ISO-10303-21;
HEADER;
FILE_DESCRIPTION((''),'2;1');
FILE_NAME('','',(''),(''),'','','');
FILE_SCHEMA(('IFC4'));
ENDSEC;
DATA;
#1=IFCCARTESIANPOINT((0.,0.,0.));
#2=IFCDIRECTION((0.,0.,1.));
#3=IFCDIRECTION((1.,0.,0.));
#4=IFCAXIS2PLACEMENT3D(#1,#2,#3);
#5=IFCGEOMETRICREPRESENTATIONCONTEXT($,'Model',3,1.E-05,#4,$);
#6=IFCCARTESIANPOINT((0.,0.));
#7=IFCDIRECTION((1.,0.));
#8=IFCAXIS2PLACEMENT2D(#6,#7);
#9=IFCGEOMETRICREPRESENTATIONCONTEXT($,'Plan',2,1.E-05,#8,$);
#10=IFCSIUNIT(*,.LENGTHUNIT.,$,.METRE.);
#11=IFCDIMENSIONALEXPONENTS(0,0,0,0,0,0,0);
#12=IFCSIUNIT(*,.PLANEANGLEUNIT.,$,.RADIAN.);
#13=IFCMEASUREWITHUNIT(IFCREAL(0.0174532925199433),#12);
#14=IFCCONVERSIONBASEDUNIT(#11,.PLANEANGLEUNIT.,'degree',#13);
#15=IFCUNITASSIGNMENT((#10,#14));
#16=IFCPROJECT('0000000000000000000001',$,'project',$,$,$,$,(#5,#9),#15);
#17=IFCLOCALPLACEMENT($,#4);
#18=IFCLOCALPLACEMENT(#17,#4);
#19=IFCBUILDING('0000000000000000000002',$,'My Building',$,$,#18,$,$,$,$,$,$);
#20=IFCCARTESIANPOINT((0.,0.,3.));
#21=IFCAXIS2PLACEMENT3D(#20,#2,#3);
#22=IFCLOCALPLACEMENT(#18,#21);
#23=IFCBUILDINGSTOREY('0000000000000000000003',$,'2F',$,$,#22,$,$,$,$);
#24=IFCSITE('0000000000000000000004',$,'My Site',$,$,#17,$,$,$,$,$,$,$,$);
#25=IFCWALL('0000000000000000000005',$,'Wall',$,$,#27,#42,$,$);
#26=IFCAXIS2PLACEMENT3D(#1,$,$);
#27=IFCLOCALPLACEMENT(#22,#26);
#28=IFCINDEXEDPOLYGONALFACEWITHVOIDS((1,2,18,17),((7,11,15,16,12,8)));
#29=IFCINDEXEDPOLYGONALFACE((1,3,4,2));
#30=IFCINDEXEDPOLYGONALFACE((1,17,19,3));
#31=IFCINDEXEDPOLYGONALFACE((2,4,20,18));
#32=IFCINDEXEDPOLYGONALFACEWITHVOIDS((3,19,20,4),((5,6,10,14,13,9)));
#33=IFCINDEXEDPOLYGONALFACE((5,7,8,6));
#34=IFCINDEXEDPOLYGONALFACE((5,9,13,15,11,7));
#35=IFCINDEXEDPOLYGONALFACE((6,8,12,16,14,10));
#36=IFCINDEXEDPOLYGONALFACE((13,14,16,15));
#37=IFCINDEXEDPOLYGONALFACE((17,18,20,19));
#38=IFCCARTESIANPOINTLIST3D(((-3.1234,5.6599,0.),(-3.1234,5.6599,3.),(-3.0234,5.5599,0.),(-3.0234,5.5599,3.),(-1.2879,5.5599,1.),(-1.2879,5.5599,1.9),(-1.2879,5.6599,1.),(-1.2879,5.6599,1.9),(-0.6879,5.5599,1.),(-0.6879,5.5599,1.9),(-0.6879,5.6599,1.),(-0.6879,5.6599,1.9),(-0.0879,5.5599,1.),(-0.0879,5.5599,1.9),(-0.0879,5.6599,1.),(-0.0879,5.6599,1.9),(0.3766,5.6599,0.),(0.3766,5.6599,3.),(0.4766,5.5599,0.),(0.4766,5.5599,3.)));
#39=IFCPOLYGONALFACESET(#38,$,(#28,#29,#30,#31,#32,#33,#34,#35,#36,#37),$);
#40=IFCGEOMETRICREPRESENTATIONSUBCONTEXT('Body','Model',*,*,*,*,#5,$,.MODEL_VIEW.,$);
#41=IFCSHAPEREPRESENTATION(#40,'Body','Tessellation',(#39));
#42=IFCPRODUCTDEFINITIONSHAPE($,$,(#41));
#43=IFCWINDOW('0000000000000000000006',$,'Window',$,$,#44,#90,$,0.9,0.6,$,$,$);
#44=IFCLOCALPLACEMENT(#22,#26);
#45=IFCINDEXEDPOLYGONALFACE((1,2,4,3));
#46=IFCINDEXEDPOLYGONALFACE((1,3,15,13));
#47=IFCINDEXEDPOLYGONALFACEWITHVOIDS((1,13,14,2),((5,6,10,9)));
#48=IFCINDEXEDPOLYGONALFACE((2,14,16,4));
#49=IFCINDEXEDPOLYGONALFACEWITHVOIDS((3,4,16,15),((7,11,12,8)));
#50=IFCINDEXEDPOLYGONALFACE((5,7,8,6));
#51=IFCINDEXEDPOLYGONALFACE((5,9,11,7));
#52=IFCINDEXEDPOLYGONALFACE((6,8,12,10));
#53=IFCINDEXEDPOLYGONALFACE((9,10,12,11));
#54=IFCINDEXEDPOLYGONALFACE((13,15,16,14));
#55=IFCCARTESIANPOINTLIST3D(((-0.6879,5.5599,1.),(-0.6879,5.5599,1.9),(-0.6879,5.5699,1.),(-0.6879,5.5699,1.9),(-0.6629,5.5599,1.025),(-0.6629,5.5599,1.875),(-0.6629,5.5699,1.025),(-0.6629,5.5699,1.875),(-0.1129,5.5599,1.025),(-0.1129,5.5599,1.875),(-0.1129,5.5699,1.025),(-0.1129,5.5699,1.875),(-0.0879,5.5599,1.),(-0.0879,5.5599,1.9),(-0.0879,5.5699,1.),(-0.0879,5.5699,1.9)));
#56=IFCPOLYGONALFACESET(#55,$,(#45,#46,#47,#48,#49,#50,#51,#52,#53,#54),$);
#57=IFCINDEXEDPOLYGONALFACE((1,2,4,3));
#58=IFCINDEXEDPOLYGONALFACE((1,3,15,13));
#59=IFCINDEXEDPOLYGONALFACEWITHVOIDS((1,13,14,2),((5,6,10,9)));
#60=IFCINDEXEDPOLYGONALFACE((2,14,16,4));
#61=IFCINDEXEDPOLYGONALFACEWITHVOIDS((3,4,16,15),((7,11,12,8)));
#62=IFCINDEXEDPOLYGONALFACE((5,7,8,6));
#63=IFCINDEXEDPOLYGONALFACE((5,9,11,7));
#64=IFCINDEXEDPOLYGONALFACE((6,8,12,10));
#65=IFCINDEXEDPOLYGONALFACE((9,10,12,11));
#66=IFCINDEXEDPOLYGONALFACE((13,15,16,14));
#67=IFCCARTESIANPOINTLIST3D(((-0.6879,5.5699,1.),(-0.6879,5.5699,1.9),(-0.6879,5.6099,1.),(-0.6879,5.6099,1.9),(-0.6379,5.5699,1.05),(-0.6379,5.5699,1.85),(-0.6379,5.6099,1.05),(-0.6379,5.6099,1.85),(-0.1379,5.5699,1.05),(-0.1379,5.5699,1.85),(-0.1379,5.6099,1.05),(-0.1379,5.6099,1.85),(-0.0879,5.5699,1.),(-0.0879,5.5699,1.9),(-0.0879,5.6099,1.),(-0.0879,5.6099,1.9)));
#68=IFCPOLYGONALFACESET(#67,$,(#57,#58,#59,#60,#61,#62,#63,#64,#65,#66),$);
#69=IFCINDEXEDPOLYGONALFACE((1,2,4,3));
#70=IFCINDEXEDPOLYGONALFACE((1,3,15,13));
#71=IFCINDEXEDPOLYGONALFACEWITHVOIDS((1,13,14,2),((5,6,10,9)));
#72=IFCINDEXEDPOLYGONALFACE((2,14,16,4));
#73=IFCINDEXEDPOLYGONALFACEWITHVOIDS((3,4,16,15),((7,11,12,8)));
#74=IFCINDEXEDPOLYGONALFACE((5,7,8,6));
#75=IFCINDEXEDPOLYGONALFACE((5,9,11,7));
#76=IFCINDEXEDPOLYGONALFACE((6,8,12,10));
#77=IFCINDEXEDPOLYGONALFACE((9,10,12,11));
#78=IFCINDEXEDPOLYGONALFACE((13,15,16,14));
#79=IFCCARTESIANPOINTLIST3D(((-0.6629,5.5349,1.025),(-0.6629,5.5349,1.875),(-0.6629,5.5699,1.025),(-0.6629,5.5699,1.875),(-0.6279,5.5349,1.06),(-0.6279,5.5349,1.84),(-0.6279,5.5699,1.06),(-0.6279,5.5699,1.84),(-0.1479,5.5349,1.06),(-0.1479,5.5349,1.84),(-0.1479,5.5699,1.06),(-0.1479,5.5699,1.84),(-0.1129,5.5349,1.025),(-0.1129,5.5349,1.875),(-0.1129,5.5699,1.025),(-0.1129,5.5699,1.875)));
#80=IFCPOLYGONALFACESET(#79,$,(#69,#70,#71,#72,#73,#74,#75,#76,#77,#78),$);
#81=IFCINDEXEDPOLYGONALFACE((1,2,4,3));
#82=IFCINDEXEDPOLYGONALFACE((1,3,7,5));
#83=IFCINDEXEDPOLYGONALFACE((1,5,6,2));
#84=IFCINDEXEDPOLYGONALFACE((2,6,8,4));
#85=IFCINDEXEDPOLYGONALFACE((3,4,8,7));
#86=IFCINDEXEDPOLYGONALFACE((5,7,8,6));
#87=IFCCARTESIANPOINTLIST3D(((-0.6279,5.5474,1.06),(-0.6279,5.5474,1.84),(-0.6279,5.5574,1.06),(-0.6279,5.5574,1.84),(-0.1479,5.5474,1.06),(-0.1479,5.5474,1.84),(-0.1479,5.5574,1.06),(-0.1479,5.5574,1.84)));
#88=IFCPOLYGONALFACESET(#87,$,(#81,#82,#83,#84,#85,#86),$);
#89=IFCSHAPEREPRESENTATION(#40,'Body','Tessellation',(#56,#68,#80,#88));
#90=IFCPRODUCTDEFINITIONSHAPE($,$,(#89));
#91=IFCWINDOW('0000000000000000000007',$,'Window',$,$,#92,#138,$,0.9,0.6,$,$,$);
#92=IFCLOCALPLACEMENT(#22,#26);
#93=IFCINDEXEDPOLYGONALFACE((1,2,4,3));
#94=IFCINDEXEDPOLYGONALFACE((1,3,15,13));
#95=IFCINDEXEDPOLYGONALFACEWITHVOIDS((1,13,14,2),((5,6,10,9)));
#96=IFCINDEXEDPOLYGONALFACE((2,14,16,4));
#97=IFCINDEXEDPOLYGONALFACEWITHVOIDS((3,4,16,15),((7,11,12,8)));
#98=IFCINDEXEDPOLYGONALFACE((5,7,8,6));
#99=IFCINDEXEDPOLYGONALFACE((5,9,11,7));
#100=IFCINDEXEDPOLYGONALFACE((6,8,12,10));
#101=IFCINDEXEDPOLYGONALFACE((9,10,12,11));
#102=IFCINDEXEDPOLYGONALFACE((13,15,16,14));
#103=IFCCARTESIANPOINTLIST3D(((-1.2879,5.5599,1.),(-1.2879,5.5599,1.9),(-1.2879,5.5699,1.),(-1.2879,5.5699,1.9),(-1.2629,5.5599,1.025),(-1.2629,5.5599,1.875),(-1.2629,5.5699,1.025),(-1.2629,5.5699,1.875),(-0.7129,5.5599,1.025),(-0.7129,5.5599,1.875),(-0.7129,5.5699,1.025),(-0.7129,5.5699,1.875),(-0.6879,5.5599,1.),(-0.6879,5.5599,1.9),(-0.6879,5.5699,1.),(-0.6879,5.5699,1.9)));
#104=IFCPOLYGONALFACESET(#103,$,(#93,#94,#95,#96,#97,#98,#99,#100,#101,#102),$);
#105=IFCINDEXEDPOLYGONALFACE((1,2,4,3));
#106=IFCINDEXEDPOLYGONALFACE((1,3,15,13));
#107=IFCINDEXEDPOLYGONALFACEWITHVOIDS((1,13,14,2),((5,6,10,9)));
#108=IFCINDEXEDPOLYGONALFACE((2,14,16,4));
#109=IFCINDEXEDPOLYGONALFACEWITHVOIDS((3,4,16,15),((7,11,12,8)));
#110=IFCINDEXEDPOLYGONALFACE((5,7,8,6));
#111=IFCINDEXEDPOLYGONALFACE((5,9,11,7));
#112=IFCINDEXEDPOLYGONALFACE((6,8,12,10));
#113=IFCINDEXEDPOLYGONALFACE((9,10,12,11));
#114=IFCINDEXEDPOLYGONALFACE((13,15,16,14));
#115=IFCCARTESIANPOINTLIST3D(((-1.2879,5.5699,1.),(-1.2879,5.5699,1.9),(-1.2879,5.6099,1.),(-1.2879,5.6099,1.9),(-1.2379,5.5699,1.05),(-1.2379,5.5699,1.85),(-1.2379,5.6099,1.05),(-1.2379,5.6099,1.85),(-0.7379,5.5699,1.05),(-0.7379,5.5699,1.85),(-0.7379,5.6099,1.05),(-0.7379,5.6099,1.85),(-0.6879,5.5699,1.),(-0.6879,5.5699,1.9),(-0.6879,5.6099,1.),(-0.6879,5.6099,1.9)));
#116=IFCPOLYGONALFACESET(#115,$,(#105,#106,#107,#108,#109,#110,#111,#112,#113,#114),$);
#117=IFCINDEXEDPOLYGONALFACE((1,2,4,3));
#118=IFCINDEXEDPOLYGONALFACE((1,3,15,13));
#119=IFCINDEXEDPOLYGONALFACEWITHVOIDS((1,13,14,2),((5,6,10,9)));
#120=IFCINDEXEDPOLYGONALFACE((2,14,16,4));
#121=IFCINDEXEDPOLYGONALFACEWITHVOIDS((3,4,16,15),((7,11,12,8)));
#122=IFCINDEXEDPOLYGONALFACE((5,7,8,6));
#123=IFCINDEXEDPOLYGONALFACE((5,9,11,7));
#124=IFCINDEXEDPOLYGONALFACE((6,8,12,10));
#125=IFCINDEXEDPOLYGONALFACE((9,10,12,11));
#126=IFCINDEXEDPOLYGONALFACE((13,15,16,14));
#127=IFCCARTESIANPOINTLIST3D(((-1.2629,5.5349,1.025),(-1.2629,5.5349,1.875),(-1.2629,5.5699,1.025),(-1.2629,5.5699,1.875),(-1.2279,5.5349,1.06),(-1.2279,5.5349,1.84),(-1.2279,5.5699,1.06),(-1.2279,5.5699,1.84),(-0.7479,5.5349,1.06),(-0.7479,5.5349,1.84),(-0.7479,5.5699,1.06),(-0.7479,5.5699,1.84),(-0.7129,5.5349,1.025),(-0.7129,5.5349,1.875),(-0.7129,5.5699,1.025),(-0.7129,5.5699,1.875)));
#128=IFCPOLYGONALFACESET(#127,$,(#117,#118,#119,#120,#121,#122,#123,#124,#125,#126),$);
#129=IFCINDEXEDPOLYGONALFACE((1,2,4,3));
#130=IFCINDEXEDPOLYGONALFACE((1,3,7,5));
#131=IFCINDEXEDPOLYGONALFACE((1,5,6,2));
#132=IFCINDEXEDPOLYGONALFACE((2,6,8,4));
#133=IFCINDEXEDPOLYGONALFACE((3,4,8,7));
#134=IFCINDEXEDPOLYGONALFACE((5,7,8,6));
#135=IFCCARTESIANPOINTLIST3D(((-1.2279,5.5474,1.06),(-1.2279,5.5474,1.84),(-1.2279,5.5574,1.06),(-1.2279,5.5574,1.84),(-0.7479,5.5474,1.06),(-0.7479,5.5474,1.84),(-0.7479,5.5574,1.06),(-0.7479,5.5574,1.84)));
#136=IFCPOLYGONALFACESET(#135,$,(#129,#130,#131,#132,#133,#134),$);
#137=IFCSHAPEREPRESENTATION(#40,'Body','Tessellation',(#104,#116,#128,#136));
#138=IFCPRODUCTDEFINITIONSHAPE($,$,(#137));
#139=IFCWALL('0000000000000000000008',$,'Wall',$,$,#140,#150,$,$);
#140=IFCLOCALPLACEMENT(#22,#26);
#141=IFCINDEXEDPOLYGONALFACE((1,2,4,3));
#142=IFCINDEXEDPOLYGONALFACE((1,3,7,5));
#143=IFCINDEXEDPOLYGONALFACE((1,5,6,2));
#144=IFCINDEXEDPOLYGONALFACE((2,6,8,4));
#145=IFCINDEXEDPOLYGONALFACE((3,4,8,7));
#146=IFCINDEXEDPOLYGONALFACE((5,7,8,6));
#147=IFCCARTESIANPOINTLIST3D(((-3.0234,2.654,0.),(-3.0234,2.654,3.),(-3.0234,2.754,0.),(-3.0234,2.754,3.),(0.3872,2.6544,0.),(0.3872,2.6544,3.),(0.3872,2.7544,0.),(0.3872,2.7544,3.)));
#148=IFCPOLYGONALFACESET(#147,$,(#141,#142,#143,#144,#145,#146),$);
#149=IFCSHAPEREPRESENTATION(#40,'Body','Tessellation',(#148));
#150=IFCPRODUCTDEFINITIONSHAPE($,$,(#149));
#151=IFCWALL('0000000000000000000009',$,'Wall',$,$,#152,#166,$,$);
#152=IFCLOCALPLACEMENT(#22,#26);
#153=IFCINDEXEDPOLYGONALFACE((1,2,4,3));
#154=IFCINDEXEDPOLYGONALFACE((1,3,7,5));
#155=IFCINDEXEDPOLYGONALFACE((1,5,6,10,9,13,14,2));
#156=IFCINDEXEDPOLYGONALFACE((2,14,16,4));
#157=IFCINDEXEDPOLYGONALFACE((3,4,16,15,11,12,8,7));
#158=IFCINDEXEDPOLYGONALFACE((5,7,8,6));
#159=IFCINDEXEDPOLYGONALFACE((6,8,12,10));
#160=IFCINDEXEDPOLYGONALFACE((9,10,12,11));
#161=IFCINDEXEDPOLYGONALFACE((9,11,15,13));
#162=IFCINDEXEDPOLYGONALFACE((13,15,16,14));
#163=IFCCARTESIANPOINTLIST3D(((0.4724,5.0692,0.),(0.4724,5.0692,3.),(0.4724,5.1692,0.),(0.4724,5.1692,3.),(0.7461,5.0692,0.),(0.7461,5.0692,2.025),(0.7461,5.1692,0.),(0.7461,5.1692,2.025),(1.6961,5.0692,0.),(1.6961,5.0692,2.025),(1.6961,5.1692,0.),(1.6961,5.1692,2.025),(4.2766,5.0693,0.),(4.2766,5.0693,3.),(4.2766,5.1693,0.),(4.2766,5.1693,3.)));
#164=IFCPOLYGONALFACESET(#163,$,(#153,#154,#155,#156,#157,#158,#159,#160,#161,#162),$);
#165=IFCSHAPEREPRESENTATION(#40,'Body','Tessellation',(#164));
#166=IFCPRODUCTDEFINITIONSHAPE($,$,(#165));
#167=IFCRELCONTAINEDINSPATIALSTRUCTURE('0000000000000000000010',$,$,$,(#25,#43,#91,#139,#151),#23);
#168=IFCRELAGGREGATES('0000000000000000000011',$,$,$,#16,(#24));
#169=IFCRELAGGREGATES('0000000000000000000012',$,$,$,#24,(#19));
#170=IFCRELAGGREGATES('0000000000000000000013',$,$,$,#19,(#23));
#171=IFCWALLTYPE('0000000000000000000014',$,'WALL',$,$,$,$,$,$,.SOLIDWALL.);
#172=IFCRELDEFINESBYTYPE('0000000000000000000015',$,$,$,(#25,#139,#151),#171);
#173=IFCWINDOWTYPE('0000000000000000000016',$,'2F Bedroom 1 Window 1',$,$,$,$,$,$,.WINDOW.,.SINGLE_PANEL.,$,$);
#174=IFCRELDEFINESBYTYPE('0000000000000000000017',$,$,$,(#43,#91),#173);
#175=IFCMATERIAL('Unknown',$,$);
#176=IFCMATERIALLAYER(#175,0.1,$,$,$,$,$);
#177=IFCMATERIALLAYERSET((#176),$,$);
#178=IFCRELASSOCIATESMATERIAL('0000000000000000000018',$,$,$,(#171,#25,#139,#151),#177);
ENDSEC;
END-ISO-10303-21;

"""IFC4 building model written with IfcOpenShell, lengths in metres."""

from ifc_helpers import new_model, entity, si_unit, converted_unit, frame, origin_with_axes, origin_2d_with_axis, place, context, subcontext, project, spatial, line, indexed_curve, outline, extrude, shape, source, transform, mapped, material, layer, layer_set, layer_usage, type_object, type_shapes, element, fill, save


model = new_model("IFC4")

# Units and contexts
model_context = context("Model", 3, precision=1e-05, world=origin_with_axes())
plan_context = context("Plan", 2, precision=1e-05, world=origin_2d_with_axis())
body_context_1 = subcontext(model_context, "Body", "Model", "MODEL_VIEW")
body_context_2 = subcontext(plan_context, "Body", "Plan", "PLAN_VIEW")
ifc_project = project(units=[si_unit("LENGTHUNIT", "METRE"), converted_unit("PLANEANGLEUNIT", "degree", entity("IfcReal", 0.0174532925199433), si_unit("PLANEANGLEUNIT", "RADIAN"), dimensions=[0, 0, 0, 0, 0, 0, 0])], contexts=[model_context, plan_context])

# Site, building, storey
site_placement = place(None, origin_with_axes())
site = spatial("IfcSite", under=ifc_project, at=site_placement, Name="My Site")
building_placement = place(site_placement, origin_with_axes())
building = spatial("IfcBuilding", under=site, at=building_placement, Name="My Building")
storey_placement = place(building_placement, frame((0.0, 0.0, 3.0), z_axis=(0.0, 0.0, 1.0), x_axis=(1.0, 0.0, 0.0)))
storey = spatial("IfcBuildingStorey", under=building, at=storey_placement, Name="2F")

# Shared definitions
ifc_material = material(Name="Unknown")

# Shared definitions
ifc_layer_1 = layer(ifc_material, 0.1)
ifc_layer_set_1 = layer_set([ifc_layer_1])
wall_type = type_object("IfcWallType", Name="WALL", PredefinedType="SOLIDWALL", material=ifc_layer_set_1)

# Wall, openings, windows
ifc_layer_usage_1 = layer_usage(ifc_layer_set_1, "AXIS2", "POSITIVE", 0.0)
wall_1_placement = place(storey_placement, frame((0.3766, 5.6599, 0.0), z_axis=(0.0, 0.0, 1.0), x_axis=(-1.0, 0.0, 0.0)))
wall_1 = element("IfcWall", 1, at=wall_1_placement, inside=storey, type_object=wall_type, material=ifc_layer_usage_1, Name="Wall", context=body_context_1, shape_type="SweptSolid", body=[
    extrude(outline(indexed_curve([(0.0, 0.0), (-0.1, 0.1), (3.4, 0.1), (3.5, 0.0)], segments=[line(1, 2, 3, 4, 1)])), origin_with_axes(), (0.0, 0.0, 1.0), 3.0),
])
shared_shape_1 = source(origin_with_axes(), body_context_1, "Body", "SweptSolid", [
    extrude(outline(indexed_curve([(0.0, 0.0), (0.6, 0.0), (0.6, 0.9), (0.0, 0.9)], segments=[line(1, 2, 3, 4, 1)])), frame((0.0, -0.6, 0.0), z_axis=(0.0, -1.0, 0.0), x_axis=(1.0, 0.0, 0.0)), (0.0, 0.0, -1.0), 1.2),
])
opening_1_placement = place(wall_1_placement, frame((0.4645, 0.0, 1.0), z_axis=(0.0, 0.0, 1.0), x_axis=(1.0, 0.0, 0.0)))
opening_1 = element("IfcOpeningElement", 2, at=opening_1_placement, cuts=wall_1, PredefinedType="OPENING", context=body_context_1, shape_type="MappedRepresentation", body=[
    mapped(shared_shape_1, transform((0.0, 0.0, 0.0), x_axis=(1.0, 0.0, 0.0), y_axis=(0.0, 1.0, 0.0), z_axis=(0.0, 0.0, 1.0), scale=1.0)),
])
opening_2_placement = place(wall_1_placement, frame((1.0645, 0.0, 1.0), z_axis=(0.0, 0.0, 1.0), x_axis=(1.0, 0.0, 0.0)))
opening_2 = element("IfcOpeningElement", 3, at=opening_2_placement, cuts=wall_1, PredefinedType="OPENING", context=body_context_1, shape_type="MappedRepresentation", body=[
    mapped(shared_shape_1, transform((0.0, 0.0, 0.0), x_axis=(1.0, 0.0, 0.0), y_axis=(0.0, 1.0, 0.0), z_axis=(0.0, 0.0, 1.0), scale=1.0)),
])
window_type_1 = type_object("IfcWindowType", Name="2F Bedroom 1 Window 1", PartitioningType="SINGLE_PANEL", PredefinedType="WINDOW")
shared_shape_2 = source(origin_with_axes(), body_context_1, "Body", "SweptSolid", [
    extrude(outline(indexed_curve([(0.0, 0.0), (0.6, 0.0), (0.6, 0.9), (0.0, 0.9)], segments=[line(1, 2, 3, 4, 1)]), holes=[indexed_curve([(0.025, 0.025), (0.575, 0.025), (0.575, 0.875), (0.025, 0.875)], segments=[line(1, 2, 3, 4, 1)])]), frame((0.0, 0.09, 0.0), z_axis=(0.0, -1.0, 0.0), x_axis=(1.0, 0.0, 0.0)), (0.0, 0.0, -1.0), 0.01),
    extrude(outline(indexed_curve([(0.0, 0.0), (0.6, 0.0), (0.6, 0.9), (0.0, 0.9)], segments=[line(1, 2, 3, 4, 1)]), holes=[indexed_curve([(0.05, 0.05), (0.55, 0.05), (0.55, 0.85), (0.05, 0.85)], segments=[line(1, 2, 3, 4, 1)])]), frame((0.0, 0.05, 0.0), z_axis=(0.0, -1.0, 0.0), x_axis=(1.0, 0.0, 0.0)), (0.0, 0.0, -1.0), 0.04),
    extrude(outline(indexed_curve([(0.0, 0.0), (0.55, 0.0), (0.55, 0.85), (0.0, 0.85)], segments=[line(1, 2, 3, 4, 1)]), holes=[indexed_curve([(0.035, 0.035), (0.515, 0.035), (0.515, 0.815), (0.035, 0.815)], segments=[line(1, 2, 3, 4, 1)])]), frame((0.025, 0.09, 0.025), z_axis=(0.0, -1.0, 0.0), x_axis=(1.0, 0.0, 0.0)), (0.0, 0.0, -1.0), 0.035),
    extrude(outline(indexed_curve([(0.035, 0.035), (0.515, 0.035), (0.515, 0.815), (0.035, 0.815)], segments=[line(1, 2, 3, 4, 1)])), frame((0.025, 0.1025, 0.025), z_axis=(0.0, -1.0, 0.0), x_axis=(1.0, 0.0, 0.0)), (0.0, 0.0, -1.0), 0.01),
])
shared_shape_3 = source(origin_with_axes(), body_context_2, "Body", "Curve2D", [
    entity("IfcIndexedPolyCurve", entity("IfcCartesianPointList2D", [[0.05, 0.05], [0.55, 0.05]])),
    entity("IfcIndexedPolyCurve", entity("IfcCartesianPointList2D", [[0.0, 0.1], [0.025, 0.1], [0.025, 0.09], [0.05, 0.09], [0.05, 0.05], [0.0, 0.05]]), [entity("IfcLineIndex", [1, 2, 3, 4, 5, 6, 1])]),
    entity("IfcIndexedPolyCurve", entity("IfcCartesianPointList2D", [[0.6, 0.1], [0.575, 0.1], [0.575, 0.09], [0.55, 0.09], [0.55, 0.05], [0.6, 0.05]]), [entity("IfcLineIndex", [1, 2, 3, 4, 5, 6, 1])]),
    entity("IfcIndexedPolyCurve", entity("IfcCartesianPointList2D", [[0.025, 0.09], [0.06, 0.09], [0.06, 0.125], [0.025, 0.125]]), [entity("IfcLineIndex", [1, 2, 3, 4, 1])]),
    entity("IfcIndexedPolyCurve", entity("IfcCartesianPointList2D", [[0.575, 0.09], [0.54, 0.09], [0.54, 0.125], [0.575, 0.125]]), [entity("IfcLineIndex", [1, 2, 3, 4, 1])]),
    entity("IfcIndexedPolyCurve", entity("IfcCartesianPointList2D", [[0.06, 0.09], [0.54, 0.09]])),
    entity("IfcIndexedPolyCurve", entity("IfcCartesianPointList2D", [[0.06, 0.125], [0.54, 0.125]])),
    entity("IfcIndexedPolyCurve", entity("IfcCartesianPointList2D", [[0.06, 0.1075], [0.54, 0.1075]])),
])
type_shapes(window_type_1, [shared_shape_2, shared_shape_3])
window_1_placement = place(opening_1_placement, frame((0.0, 0.0, 0.0), z_axis=(0.0, 0.0, 1.0), x_axis=(1.0, 0.0, 0.0)))
window_1 = element("IfcWindow", 4, at=window_1_placement, inside=storey, type_object=window_type_1, Name="Window", OverallHeight=0.9, OverallWidth=0.6, shapes=[
    shape(body_context_1, "Body", "MappedRepresentation", [mapped(shared_shape_2, transform((0.0, 0.0, 0.0), x_axis=(1.0, 0.0, 0.0), y_axis=(0.0, 1.0, 0.0), z_axis=(0.0, 0.0, 1.0), scale=1.0))]),
    shape(body_context_2, "Body", "MappedRepresentation", [mapped(shared_shape_3, transform((0.0, 0.0, 0.0), x_axis=(1.0, 0.0, 0.0), y_axis=(0.0, 1.0, 0.0), z_axis=(0.0, 0.0, 1.0), scale=1.0))]),
])
fill(opening_1, window_1)
window_2_placement = place(opening_2_placement, frame((0.0, 0.0, 0.0), z_axis=(0.0, 0.0, 1.0), x_axis=(1.0, 0.0, 0.0)))
window_2 = element("IfcWindow", 5, at=window_2_placement, inside=storey, type_object=window_type_1, Name="Window", OverallHeight=0.9, OverallWidth=0.6, shapes=[
    shape(body_context_1, "Body", "MappedRepresentation", [mapped(shared_shape_2, transform((0.0, 0.0, 0.0), x_axis=(1.0, 0.0, 0.0), y_axis=(0.0, 1.0, 0.0), z_axis=(0.0, 0.0, 1.0), scale=1.0))]),
    shape(body_context_2, "Body", "MappedRepresentation", [mapped(shared_shape_3, transform((0.0, 0.0, 0.0), x_axis=(1.0, 0.0, 0.0), y_axis=(0.0, 1.0, 0.0), z_axis=(0.0, 0.0, 1.0), scale=1.0))]),
])
fill(opening_2, window_2)

# Wall
ifc_layer_usage_2 = layer_usage(ifc_layer_set_1, "AXIS2", "POSITIVE", 0.0)
wall_2_placement = place(storey_placement, frame((-3.0234, 2.654, 0.0), z_axis=(0.0, 0.0, 1.0), x_axis=(1.0, 0.000117, 0.0)))
element("IfcWall", 6, at=wall_2_placement, inside=storey, type_object=wall_type, material=ifc_layer_usage_2, Name="Wall", context=body_context_1, shape_type="SweptSolid", body=[
    extrude(outline(indexed_curve([(0.0, 0.0), (0.0, 0.1), (3.4106, 0.1), (3.4106, 0.0)], segments=[line(1, 2, 3, 4, 1)])), origin_with_axes(), (0.0, 0.0, 1.0), 3.0),
])

# Wall, opening
ifc_layer_usage_3 = layer_usage(ifc_layer_set_1, "AXIS2", "POSITIVE", 0.0)
wall_3_placement = place(storey_placement, frame((4.2766, 5.1693, 0.0), z_axis=(0.0, 0.0, 1.0), x_axis=(-1.0, -0.000042, 0.0)))
wall_3 = element("IfcWall", 7, at=wall_3_placement, inside=storey, type_object=wall_type, material=ifc_layer_usage_3, Name="Wall", context=body_context_1, shape_type="SweptSolid", body=[
    extrude(outline(indexed_curve([(0.0, 0.0), (0.0, 0.1), (3.8042, 0.1), (3.8042, 0.0)], segments=[line(1, 2, 3, 4, 1)])), origin_with_axes(), (0.0, 0.0, 1.0), 3.0),
])
shared_shape_4 = source(origin_with_axes(), body_context_1, "Body", "SweptSolid", [
    extrude(outline(indexed_curve([(0.0, 0.0), (0.95, 0.0), (0.95, 2.025), (0.0, 2.025)], segments=[line(1, 2, 3, 4, 1)])), frame((-0.025, -0.6, 0.0), z_axis=(0.0, -1.0, 0.0), x_axis=(1.0, 0.0, 0.0)), (0.0, 0.0, -1.0), 1.2),
])
opening_3_placement = place(wall_3_placement, frame((2.6055, 0.0, 0.0), z_axis=(0.0, 0.0, 1.0), x_axis=(1.0, 0.0, 0.0)))
element("IfcOpeningElement", 8, at=opening_3_placement, cuts=wall_3, PredefinedType="OPENING", context=body_context_1, shape_type="MappedRepresentation", body=[
    mapped(shared_shape_4, transform((0.0, 0.0, 0.0), x_axis=(1.0, 0.0, 0.0), y_axis=(0.0, 1.0, 0.0), z_axis=(0.0, 0.0, 1.0), scale=1.0)),
])

save(model, "model.ifc")
